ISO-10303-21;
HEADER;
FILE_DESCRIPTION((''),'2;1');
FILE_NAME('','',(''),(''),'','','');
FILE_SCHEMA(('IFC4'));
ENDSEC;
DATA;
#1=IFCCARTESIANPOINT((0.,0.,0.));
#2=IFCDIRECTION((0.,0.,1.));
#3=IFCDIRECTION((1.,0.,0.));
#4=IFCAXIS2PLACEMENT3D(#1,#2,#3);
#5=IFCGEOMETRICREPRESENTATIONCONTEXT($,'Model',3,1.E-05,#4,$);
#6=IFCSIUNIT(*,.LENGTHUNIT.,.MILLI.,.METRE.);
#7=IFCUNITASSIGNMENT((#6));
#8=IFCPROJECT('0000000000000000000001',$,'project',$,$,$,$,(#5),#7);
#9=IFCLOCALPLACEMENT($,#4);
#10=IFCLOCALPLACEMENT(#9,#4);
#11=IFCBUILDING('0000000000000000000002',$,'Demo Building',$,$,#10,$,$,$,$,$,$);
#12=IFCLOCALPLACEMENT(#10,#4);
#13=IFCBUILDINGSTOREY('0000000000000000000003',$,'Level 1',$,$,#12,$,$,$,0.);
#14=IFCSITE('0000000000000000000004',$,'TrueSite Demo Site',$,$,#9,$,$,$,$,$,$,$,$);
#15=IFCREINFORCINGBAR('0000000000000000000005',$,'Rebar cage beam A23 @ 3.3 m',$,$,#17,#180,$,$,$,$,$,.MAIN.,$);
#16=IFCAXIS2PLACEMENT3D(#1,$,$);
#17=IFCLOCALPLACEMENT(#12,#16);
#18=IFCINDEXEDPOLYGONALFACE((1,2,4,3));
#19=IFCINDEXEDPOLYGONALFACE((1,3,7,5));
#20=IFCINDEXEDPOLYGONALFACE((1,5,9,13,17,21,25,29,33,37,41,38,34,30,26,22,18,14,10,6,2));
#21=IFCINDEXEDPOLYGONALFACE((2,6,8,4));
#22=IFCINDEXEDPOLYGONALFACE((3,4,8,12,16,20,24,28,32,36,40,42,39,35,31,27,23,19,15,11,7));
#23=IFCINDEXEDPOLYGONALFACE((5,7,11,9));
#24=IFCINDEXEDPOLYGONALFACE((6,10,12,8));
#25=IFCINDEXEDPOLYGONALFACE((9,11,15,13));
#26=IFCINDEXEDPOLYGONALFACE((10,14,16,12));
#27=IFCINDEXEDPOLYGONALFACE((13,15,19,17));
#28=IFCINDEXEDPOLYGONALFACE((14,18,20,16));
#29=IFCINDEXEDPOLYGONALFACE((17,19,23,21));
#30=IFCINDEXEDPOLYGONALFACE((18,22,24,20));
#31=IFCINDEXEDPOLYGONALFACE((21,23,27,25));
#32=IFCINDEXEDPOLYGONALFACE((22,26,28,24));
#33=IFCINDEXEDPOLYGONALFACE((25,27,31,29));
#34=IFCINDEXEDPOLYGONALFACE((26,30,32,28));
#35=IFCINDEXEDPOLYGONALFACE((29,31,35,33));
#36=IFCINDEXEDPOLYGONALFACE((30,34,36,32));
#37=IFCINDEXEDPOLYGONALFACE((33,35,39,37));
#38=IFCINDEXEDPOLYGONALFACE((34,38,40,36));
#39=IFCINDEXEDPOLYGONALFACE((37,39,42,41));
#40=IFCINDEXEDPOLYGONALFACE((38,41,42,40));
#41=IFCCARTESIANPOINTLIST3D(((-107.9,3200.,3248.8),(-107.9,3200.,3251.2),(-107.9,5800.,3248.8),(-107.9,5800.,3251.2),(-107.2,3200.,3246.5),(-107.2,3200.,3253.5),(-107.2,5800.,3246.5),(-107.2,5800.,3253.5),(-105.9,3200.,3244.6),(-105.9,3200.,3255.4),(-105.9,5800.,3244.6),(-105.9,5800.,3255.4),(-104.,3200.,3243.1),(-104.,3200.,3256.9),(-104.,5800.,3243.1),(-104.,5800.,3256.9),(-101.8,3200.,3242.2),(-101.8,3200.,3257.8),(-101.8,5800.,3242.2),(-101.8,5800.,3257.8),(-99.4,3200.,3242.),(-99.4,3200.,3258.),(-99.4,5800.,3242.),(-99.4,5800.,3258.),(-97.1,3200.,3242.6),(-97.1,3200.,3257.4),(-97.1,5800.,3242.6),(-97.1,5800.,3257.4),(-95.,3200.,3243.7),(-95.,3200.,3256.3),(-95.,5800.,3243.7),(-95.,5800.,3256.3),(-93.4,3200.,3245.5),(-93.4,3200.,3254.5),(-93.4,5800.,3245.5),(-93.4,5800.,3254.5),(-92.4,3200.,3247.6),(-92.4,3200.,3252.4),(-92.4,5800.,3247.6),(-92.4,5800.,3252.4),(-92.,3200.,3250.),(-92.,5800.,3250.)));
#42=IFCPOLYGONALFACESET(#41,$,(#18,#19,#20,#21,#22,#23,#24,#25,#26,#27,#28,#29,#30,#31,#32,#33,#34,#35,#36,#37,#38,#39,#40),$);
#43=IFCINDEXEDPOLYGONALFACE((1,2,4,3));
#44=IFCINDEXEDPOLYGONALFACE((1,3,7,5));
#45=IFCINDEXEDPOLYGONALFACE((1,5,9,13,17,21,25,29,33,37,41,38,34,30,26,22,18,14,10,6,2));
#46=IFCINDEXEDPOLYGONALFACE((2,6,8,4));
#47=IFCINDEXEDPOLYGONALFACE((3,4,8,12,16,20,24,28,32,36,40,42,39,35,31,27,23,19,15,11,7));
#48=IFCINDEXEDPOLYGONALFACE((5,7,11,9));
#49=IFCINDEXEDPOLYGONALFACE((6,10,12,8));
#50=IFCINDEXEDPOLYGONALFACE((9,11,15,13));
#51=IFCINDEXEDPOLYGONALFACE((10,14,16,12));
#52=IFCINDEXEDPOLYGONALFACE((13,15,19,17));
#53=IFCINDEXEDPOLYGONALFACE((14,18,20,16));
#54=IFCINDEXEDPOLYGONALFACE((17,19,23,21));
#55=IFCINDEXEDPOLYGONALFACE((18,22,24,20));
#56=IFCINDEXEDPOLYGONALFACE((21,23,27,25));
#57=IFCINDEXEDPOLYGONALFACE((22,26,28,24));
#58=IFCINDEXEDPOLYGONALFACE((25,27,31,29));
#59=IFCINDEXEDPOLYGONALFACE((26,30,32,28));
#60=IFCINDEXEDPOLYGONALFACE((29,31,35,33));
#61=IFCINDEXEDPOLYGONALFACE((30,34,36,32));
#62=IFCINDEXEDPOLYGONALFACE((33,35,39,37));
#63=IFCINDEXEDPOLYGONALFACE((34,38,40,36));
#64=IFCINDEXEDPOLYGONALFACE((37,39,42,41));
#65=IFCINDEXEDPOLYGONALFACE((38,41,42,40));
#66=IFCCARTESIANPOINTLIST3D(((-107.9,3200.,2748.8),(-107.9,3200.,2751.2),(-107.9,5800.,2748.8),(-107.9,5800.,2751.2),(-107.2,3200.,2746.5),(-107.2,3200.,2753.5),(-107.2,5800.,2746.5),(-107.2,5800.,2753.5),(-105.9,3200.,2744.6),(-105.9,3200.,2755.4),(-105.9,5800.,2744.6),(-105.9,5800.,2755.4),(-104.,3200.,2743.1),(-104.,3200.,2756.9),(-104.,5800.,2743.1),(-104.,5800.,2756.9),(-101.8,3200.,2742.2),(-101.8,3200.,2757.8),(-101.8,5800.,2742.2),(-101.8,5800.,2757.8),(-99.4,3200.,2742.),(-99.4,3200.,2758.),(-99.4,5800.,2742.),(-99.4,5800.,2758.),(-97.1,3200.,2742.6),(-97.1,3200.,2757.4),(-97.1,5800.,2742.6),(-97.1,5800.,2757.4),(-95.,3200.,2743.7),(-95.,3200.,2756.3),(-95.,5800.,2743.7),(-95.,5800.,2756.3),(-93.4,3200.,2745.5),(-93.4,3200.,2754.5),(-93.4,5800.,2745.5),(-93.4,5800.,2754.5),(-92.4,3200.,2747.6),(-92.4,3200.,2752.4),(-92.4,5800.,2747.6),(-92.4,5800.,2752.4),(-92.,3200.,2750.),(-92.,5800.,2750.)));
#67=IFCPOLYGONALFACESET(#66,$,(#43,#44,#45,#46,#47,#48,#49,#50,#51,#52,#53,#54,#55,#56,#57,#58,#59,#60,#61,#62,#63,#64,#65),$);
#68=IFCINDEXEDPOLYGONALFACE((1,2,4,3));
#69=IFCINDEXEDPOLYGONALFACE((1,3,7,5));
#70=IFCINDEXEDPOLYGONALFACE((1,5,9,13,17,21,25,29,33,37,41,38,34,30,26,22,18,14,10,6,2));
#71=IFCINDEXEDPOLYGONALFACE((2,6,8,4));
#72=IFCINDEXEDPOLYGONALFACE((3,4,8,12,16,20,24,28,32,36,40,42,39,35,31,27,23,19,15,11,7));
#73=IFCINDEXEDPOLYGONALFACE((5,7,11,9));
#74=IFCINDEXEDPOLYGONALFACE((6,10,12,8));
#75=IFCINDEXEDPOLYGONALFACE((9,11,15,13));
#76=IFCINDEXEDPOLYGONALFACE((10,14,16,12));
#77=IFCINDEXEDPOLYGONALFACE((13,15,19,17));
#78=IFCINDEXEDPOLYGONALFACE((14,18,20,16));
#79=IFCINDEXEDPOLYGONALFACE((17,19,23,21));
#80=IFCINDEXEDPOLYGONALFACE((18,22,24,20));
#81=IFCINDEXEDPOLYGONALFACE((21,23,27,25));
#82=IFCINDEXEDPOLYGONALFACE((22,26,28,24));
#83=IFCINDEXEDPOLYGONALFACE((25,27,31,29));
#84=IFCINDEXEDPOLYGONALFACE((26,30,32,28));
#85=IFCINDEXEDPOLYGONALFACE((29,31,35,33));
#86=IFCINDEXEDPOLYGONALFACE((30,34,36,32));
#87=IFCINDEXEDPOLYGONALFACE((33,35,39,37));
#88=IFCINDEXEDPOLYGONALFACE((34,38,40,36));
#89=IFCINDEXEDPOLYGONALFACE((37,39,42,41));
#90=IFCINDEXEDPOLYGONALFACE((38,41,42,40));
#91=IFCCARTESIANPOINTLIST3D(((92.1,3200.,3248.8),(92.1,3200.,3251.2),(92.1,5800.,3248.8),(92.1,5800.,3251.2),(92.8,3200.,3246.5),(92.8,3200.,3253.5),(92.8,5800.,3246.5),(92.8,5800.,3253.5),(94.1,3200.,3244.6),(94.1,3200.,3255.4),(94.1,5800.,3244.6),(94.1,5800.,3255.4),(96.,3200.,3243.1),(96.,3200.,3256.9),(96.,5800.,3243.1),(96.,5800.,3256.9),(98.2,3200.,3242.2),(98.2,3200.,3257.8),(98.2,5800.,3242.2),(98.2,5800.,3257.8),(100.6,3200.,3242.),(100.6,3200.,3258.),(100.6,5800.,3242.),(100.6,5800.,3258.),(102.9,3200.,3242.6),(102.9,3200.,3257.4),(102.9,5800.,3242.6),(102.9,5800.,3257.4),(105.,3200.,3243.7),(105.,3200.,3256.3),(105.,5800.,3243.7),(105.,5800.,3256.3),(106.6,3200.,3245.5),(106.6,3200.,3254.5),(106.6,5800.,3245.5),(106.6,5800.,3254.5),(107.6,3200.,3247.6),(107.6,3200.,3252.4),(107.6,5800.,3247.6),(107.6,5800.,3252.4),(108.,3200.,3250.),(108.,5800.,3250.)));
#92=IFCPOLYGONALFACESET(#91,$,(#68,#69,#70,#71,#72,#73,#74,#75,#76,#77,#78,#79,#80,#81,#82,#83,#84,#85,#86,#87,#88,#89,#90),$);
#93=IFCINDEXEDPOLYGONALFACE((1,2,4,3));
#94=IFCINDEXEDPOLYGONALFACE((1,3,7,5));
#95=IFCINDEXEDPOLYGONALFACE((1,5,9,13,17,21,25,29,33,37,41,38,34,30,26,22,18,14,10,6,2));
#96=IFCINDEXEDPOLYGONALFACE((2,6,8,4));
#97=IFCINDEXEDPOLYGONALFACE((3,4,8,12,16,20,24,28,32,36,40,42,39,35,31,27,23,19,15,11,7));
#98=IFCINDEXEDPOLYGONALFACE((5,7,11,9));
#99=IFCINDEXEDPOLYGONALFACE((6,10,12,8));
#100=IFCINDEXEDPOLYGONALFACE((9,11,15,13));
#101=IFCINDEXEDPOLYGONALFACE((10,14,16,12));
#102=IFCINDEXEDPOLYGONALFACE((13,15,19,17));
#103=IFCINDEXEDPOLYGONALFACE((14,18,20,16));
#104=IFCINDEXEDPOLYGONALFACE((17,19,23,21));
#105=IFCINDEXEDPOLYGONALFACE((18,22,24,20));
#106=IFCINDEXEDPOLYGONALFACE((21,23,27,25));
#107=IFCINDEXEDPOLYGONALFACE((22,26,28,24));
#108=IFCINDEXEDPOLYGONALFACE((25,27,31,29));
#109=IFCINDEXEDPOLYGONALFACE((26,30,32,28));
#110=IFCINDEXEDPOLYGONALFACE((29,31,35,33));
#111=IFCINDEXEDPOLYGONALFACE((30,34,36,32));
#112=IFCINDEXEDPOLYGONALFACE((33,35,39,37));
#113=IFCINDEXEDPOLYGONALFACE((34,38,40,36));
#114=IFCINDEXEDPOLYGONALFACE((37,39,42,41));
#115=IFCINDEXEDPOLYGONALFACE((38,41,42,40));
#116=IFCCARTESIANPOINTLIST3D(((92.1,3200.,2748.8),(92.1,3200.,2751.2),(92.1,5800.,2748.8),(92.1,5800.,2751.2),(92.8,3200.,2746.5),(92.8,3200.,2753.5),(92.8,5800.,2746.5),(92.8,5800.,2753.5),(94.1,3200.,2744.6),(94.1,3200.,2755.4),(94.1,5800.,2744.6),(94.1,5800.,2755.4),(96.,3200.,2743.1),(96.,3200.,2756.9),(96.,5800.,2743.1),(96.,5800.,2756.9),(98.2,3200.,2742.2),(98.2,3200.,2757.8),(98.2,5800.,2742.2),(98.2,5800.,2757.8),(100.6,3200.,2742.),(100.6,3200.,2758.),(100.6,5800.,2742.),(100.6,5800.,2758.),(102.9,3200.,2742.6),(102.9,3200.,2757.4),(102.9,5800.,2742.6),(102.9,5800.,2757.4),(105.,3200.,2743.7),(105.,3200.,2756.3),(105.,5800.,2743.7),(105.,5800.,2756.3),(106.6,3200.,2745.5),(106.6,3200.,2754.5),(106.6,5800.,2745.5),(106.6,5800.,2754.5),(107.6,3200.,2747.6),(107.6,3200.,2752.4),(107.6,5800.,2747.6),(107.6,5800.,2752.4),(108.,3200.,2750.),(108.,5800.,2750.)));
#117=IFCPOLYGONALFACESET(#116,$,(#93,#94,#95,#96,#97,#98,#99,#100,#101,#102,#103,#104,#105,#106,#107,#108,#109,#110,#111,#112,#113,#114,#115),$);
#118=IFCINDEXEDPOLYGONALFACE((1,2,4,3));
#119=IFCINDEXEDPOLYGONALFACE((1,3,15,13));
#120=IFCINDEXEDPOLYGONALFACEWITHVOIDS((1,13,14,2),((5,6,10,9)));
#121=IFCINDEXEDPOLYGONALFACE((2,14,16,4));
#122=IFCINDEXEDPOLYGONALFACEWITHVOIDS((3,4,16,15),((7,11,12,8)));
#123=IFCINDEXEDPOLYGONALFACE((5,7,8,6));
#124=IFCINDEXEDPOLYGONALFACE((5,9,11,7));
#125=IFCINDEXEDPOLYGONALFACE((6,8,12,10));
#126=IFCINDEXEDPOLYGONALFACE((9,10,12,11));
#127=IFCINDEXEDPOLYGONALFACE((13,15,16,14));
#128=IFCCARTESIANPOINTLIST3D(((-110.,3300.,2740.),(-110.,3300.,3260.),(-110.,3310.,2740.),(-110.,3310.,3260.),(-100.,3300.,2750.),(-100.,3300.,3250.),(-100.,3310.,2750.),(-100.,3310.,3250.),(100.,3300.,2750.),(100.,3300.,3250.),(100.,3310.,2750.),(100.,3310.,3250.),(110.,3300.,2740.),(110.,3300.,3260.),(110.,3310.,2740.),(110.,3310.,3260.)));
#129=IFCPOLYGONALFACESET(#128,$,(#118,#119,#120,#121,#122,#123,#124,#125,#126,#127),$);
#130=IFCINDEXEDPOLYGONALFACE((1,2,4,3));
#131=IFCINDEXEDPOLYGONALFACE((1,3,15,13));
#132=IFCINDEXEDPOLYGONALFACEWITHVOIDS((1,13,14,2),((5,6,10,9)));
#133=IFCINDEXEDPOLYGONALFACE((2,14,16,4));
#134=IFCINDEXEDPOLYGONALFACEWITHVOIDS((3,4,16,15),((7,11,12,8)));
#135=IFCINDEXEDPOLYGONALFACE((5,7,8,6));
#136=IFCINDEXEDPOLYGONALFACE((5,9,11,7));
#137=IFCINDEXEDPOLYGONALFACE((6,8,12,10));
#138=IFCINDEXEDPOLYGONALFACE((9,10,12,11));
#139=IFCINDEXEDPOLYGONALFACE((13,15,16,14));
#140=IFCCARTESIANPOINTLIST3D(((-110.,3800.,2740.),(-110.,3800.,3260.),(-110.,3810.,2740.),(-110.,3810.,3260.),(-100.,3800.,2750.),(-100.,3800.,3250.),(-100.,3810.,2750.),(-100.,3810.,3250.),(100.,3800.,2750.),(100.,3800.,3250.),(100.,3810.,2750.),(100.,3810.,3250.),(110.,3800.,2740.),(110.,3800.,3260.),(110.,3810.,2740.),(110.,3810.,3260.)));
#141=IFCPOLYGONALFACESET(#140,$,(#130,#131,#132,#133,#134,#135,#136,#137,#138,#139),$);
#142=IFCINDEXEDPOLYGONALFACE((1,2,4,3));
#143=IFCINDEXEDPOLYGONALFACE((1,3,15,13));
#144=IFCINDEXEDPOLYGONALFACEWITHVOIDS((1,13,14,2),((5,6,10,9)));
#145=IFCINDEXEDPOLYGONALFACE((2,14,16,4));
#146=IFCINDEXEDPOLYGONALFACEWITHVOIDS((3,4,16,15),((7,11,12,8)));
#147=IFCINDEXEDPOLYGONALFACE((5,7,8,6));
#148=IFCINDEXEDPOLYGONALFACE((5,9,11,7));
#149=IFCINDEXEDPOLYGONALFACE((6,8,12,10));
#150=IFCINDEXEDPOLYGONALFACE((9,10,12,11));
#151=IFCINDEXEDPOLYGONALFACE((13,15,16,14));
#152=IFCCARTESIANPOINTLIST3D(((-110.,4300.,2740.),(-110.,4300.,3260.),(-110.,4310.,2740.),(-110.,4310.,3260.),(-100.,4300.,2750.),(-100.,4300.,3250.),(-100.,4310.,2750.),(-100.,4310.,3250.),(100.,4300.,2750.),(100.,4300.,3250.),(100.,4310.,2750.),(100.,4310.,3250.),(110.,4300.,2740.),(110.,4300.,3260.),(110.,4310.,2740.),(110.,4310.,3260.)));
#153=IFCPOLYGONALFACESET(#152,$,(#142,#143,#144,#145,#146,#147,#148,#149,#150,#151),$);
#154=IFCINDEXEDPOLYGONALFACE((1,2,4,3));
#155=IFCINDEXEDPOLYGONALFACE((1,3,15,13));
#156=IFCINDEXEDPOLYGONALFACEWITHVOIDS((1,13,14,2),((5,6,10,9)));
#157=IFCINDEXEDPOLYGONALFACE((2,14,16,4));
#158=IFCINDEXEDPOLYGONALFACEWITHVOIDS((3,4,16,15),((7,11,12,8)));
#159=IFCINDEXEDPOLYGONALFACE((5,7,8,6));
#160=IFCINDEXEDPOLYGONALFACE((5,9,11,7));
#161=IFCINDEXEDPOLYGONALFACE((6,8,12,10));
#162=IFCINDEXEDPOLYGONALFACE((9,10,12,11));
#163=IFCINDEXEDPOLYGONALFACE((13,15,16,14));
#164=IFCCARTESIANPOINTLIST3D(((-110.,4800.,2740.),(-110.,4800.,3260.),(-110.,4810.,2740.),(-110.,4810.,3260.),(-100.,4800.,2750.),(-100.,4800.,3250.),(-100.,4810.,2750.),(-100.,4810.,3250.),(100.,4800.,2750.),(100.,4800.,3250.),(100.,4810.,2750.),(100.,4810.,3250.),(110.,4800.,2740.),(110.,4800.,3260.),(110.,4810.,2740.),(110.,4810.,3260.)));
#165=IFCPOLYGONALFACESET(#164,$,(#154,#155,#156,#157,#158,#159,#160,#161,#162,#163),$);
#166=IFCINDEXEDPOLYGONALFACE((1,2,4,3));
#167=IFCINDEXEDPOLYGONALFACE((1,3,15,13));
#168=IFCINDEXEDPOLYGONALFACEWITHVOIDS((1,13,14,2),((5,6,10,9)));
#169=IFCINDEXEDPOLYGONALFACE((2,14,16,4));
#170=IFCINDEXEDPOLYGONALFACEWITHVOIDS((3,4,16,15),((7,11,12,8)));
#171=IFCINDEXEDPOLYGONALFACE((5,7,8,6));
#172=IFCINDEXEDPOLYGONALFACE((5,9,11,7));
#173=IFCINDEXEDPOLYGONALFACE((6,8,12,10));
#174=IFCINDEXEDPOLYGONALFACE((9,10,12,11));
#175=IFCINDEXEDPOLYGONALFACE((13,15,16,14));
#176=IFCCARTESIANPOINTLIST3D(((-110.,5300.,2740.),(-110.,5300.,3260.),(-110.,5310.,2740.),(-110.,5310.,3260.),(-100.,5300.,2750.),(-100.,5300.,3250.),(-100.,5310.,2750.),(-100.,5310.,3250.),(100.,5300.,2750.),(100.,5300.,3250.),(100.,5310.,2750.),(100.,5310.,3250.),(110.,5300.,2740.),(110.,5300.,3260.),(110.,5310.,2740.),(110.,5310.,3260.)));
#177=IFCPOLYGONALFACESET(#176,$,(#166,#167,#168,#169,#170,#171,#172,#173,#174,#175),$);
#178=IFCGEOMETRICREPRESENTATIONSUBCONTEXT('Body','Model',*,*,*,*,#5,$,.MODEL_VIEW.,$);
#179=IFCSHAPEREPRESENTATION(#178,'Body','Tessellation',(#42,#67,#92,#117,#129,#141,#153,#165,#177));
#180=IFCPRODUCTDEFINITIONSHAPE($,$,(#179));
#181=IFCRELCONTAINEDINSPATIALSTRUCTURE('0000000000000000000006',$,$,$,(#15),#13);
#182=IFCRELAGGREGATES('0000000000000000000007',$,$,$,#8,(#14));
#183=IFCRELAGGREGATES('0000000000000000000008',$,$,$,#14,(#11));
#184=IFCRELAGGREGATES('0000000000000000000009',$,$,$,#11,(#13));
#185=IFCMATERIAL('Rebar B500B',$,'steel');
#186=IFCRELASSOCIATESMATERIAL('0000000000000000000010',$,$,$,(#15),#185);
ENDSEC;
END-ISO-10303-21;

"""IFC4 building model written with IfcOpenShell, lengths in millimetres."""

from ifc_helpers import new_model, si_unit, frame, origin_with_axes, place, context, subcontext, project, spatial, hollow_rectangle, circle, extrude, material, element, save


model = new_model("IFC4")

# Units and contexts
model_context = context("Model", 3, precision=1e-05, world=origin_with_axes())
body_context = subcontext(model_context, "Body", "Model", "MODEL_VIEW")
ifc_project = project(units=[si_unit("LENGTHUNIT", "METRE", prefix="MILLI")], contexts=[model_context])

# Site, building, storey
site_placement = place(None, origin_with_axes())
site = spatial("IfcSite", under=ifc_project, at=site_placement, Name="TrueSite Demo Site")
building_placement = place(site_placement, origin_with_axes())
building = spatial("IfcBuilding", under=site, at=building_placement, Name="Demo Building")
storey_placement = place(building_placement, origin_with_axes())
storey = spatial("IfcBuildingStorey", under=building, at=storey_placement, Name="Level 1", Elevation=0.0)

# Reinforcing bar
ifc_material_1 = material(Name="Rebar B500B", Category="steel")
for number, where, z_axis, x_axis, name in (
    (1, (0.0, 3200.0, 3000.0), (0.0, 1.0, 0.0), (1.0, 0.0, 0.0), "Rebar cage beam A23 @ 3.3 m"),
):
    element("IfcReinforcingBar", number, at=place(storey_placement, frame(where, z_axis=z_axis, x_axis=x_axis)), inside=storey, material=ifc_material_1, Name=name, PredefinedType="MAIN", context=body_context, shape_type="SweptSolid", body=[
        extrude(circle(Radius=8.0), frame((-100.0, -250.0, 0.0)), (0.0, 0.0, 1.0), 2600.0),
        extrude(circle(Radius=8.0), frame((-100.0, 250.0, 0.0)), (0.0, 0.0, 1.0), 2600.0),
        extrude(circle(Radius=8.0), frame((100.0, -250.0, 0.0)), (0.0, 0.0, 1.0), 2600.0),
        extrude(circle(Radius=8.0), frame((100.0, 250.0, 0.0)), (0.0, 0.0, 1.0), 2600.0),
        extrude(hollow_rectangle(XDim=220.0, YDim=520.0, WallThickness=10.0), frame((0.0, 0.0, 100.0)), (0.0, 0.0, 1.0), 10.0),
        extrude(hollow_rectangle(XDim=220.0, YDim=520.0, WallThickness=10.0), frame((0.0, 0.0, 600.0)), (0.0, 0.0, 1.0), 10.0),
        extrude(hollow_rectangle(XDim=220.0, YDim=520.0, WallThickness=10.0), frame((0.0, 0.0, 1100.0)), (0.0, 0.0, 1.0), 10.0),
        extrude(hollow_rectangle(XDim=220.0, YDim=520.0, WallThickness=10.0), frame((0.0, 0.0, 1600.0)), (0.0, 0.0, 1.0), 10.0),
        extrude(hollow_rectangle(XDim=220.0, YDim=520.0, WallThickness=10.0), frame((0.0, 0.0, 2100.0)), (0.0, 0.0, 1.0), 10.0),
    ])

save(model, "model.ifc")
